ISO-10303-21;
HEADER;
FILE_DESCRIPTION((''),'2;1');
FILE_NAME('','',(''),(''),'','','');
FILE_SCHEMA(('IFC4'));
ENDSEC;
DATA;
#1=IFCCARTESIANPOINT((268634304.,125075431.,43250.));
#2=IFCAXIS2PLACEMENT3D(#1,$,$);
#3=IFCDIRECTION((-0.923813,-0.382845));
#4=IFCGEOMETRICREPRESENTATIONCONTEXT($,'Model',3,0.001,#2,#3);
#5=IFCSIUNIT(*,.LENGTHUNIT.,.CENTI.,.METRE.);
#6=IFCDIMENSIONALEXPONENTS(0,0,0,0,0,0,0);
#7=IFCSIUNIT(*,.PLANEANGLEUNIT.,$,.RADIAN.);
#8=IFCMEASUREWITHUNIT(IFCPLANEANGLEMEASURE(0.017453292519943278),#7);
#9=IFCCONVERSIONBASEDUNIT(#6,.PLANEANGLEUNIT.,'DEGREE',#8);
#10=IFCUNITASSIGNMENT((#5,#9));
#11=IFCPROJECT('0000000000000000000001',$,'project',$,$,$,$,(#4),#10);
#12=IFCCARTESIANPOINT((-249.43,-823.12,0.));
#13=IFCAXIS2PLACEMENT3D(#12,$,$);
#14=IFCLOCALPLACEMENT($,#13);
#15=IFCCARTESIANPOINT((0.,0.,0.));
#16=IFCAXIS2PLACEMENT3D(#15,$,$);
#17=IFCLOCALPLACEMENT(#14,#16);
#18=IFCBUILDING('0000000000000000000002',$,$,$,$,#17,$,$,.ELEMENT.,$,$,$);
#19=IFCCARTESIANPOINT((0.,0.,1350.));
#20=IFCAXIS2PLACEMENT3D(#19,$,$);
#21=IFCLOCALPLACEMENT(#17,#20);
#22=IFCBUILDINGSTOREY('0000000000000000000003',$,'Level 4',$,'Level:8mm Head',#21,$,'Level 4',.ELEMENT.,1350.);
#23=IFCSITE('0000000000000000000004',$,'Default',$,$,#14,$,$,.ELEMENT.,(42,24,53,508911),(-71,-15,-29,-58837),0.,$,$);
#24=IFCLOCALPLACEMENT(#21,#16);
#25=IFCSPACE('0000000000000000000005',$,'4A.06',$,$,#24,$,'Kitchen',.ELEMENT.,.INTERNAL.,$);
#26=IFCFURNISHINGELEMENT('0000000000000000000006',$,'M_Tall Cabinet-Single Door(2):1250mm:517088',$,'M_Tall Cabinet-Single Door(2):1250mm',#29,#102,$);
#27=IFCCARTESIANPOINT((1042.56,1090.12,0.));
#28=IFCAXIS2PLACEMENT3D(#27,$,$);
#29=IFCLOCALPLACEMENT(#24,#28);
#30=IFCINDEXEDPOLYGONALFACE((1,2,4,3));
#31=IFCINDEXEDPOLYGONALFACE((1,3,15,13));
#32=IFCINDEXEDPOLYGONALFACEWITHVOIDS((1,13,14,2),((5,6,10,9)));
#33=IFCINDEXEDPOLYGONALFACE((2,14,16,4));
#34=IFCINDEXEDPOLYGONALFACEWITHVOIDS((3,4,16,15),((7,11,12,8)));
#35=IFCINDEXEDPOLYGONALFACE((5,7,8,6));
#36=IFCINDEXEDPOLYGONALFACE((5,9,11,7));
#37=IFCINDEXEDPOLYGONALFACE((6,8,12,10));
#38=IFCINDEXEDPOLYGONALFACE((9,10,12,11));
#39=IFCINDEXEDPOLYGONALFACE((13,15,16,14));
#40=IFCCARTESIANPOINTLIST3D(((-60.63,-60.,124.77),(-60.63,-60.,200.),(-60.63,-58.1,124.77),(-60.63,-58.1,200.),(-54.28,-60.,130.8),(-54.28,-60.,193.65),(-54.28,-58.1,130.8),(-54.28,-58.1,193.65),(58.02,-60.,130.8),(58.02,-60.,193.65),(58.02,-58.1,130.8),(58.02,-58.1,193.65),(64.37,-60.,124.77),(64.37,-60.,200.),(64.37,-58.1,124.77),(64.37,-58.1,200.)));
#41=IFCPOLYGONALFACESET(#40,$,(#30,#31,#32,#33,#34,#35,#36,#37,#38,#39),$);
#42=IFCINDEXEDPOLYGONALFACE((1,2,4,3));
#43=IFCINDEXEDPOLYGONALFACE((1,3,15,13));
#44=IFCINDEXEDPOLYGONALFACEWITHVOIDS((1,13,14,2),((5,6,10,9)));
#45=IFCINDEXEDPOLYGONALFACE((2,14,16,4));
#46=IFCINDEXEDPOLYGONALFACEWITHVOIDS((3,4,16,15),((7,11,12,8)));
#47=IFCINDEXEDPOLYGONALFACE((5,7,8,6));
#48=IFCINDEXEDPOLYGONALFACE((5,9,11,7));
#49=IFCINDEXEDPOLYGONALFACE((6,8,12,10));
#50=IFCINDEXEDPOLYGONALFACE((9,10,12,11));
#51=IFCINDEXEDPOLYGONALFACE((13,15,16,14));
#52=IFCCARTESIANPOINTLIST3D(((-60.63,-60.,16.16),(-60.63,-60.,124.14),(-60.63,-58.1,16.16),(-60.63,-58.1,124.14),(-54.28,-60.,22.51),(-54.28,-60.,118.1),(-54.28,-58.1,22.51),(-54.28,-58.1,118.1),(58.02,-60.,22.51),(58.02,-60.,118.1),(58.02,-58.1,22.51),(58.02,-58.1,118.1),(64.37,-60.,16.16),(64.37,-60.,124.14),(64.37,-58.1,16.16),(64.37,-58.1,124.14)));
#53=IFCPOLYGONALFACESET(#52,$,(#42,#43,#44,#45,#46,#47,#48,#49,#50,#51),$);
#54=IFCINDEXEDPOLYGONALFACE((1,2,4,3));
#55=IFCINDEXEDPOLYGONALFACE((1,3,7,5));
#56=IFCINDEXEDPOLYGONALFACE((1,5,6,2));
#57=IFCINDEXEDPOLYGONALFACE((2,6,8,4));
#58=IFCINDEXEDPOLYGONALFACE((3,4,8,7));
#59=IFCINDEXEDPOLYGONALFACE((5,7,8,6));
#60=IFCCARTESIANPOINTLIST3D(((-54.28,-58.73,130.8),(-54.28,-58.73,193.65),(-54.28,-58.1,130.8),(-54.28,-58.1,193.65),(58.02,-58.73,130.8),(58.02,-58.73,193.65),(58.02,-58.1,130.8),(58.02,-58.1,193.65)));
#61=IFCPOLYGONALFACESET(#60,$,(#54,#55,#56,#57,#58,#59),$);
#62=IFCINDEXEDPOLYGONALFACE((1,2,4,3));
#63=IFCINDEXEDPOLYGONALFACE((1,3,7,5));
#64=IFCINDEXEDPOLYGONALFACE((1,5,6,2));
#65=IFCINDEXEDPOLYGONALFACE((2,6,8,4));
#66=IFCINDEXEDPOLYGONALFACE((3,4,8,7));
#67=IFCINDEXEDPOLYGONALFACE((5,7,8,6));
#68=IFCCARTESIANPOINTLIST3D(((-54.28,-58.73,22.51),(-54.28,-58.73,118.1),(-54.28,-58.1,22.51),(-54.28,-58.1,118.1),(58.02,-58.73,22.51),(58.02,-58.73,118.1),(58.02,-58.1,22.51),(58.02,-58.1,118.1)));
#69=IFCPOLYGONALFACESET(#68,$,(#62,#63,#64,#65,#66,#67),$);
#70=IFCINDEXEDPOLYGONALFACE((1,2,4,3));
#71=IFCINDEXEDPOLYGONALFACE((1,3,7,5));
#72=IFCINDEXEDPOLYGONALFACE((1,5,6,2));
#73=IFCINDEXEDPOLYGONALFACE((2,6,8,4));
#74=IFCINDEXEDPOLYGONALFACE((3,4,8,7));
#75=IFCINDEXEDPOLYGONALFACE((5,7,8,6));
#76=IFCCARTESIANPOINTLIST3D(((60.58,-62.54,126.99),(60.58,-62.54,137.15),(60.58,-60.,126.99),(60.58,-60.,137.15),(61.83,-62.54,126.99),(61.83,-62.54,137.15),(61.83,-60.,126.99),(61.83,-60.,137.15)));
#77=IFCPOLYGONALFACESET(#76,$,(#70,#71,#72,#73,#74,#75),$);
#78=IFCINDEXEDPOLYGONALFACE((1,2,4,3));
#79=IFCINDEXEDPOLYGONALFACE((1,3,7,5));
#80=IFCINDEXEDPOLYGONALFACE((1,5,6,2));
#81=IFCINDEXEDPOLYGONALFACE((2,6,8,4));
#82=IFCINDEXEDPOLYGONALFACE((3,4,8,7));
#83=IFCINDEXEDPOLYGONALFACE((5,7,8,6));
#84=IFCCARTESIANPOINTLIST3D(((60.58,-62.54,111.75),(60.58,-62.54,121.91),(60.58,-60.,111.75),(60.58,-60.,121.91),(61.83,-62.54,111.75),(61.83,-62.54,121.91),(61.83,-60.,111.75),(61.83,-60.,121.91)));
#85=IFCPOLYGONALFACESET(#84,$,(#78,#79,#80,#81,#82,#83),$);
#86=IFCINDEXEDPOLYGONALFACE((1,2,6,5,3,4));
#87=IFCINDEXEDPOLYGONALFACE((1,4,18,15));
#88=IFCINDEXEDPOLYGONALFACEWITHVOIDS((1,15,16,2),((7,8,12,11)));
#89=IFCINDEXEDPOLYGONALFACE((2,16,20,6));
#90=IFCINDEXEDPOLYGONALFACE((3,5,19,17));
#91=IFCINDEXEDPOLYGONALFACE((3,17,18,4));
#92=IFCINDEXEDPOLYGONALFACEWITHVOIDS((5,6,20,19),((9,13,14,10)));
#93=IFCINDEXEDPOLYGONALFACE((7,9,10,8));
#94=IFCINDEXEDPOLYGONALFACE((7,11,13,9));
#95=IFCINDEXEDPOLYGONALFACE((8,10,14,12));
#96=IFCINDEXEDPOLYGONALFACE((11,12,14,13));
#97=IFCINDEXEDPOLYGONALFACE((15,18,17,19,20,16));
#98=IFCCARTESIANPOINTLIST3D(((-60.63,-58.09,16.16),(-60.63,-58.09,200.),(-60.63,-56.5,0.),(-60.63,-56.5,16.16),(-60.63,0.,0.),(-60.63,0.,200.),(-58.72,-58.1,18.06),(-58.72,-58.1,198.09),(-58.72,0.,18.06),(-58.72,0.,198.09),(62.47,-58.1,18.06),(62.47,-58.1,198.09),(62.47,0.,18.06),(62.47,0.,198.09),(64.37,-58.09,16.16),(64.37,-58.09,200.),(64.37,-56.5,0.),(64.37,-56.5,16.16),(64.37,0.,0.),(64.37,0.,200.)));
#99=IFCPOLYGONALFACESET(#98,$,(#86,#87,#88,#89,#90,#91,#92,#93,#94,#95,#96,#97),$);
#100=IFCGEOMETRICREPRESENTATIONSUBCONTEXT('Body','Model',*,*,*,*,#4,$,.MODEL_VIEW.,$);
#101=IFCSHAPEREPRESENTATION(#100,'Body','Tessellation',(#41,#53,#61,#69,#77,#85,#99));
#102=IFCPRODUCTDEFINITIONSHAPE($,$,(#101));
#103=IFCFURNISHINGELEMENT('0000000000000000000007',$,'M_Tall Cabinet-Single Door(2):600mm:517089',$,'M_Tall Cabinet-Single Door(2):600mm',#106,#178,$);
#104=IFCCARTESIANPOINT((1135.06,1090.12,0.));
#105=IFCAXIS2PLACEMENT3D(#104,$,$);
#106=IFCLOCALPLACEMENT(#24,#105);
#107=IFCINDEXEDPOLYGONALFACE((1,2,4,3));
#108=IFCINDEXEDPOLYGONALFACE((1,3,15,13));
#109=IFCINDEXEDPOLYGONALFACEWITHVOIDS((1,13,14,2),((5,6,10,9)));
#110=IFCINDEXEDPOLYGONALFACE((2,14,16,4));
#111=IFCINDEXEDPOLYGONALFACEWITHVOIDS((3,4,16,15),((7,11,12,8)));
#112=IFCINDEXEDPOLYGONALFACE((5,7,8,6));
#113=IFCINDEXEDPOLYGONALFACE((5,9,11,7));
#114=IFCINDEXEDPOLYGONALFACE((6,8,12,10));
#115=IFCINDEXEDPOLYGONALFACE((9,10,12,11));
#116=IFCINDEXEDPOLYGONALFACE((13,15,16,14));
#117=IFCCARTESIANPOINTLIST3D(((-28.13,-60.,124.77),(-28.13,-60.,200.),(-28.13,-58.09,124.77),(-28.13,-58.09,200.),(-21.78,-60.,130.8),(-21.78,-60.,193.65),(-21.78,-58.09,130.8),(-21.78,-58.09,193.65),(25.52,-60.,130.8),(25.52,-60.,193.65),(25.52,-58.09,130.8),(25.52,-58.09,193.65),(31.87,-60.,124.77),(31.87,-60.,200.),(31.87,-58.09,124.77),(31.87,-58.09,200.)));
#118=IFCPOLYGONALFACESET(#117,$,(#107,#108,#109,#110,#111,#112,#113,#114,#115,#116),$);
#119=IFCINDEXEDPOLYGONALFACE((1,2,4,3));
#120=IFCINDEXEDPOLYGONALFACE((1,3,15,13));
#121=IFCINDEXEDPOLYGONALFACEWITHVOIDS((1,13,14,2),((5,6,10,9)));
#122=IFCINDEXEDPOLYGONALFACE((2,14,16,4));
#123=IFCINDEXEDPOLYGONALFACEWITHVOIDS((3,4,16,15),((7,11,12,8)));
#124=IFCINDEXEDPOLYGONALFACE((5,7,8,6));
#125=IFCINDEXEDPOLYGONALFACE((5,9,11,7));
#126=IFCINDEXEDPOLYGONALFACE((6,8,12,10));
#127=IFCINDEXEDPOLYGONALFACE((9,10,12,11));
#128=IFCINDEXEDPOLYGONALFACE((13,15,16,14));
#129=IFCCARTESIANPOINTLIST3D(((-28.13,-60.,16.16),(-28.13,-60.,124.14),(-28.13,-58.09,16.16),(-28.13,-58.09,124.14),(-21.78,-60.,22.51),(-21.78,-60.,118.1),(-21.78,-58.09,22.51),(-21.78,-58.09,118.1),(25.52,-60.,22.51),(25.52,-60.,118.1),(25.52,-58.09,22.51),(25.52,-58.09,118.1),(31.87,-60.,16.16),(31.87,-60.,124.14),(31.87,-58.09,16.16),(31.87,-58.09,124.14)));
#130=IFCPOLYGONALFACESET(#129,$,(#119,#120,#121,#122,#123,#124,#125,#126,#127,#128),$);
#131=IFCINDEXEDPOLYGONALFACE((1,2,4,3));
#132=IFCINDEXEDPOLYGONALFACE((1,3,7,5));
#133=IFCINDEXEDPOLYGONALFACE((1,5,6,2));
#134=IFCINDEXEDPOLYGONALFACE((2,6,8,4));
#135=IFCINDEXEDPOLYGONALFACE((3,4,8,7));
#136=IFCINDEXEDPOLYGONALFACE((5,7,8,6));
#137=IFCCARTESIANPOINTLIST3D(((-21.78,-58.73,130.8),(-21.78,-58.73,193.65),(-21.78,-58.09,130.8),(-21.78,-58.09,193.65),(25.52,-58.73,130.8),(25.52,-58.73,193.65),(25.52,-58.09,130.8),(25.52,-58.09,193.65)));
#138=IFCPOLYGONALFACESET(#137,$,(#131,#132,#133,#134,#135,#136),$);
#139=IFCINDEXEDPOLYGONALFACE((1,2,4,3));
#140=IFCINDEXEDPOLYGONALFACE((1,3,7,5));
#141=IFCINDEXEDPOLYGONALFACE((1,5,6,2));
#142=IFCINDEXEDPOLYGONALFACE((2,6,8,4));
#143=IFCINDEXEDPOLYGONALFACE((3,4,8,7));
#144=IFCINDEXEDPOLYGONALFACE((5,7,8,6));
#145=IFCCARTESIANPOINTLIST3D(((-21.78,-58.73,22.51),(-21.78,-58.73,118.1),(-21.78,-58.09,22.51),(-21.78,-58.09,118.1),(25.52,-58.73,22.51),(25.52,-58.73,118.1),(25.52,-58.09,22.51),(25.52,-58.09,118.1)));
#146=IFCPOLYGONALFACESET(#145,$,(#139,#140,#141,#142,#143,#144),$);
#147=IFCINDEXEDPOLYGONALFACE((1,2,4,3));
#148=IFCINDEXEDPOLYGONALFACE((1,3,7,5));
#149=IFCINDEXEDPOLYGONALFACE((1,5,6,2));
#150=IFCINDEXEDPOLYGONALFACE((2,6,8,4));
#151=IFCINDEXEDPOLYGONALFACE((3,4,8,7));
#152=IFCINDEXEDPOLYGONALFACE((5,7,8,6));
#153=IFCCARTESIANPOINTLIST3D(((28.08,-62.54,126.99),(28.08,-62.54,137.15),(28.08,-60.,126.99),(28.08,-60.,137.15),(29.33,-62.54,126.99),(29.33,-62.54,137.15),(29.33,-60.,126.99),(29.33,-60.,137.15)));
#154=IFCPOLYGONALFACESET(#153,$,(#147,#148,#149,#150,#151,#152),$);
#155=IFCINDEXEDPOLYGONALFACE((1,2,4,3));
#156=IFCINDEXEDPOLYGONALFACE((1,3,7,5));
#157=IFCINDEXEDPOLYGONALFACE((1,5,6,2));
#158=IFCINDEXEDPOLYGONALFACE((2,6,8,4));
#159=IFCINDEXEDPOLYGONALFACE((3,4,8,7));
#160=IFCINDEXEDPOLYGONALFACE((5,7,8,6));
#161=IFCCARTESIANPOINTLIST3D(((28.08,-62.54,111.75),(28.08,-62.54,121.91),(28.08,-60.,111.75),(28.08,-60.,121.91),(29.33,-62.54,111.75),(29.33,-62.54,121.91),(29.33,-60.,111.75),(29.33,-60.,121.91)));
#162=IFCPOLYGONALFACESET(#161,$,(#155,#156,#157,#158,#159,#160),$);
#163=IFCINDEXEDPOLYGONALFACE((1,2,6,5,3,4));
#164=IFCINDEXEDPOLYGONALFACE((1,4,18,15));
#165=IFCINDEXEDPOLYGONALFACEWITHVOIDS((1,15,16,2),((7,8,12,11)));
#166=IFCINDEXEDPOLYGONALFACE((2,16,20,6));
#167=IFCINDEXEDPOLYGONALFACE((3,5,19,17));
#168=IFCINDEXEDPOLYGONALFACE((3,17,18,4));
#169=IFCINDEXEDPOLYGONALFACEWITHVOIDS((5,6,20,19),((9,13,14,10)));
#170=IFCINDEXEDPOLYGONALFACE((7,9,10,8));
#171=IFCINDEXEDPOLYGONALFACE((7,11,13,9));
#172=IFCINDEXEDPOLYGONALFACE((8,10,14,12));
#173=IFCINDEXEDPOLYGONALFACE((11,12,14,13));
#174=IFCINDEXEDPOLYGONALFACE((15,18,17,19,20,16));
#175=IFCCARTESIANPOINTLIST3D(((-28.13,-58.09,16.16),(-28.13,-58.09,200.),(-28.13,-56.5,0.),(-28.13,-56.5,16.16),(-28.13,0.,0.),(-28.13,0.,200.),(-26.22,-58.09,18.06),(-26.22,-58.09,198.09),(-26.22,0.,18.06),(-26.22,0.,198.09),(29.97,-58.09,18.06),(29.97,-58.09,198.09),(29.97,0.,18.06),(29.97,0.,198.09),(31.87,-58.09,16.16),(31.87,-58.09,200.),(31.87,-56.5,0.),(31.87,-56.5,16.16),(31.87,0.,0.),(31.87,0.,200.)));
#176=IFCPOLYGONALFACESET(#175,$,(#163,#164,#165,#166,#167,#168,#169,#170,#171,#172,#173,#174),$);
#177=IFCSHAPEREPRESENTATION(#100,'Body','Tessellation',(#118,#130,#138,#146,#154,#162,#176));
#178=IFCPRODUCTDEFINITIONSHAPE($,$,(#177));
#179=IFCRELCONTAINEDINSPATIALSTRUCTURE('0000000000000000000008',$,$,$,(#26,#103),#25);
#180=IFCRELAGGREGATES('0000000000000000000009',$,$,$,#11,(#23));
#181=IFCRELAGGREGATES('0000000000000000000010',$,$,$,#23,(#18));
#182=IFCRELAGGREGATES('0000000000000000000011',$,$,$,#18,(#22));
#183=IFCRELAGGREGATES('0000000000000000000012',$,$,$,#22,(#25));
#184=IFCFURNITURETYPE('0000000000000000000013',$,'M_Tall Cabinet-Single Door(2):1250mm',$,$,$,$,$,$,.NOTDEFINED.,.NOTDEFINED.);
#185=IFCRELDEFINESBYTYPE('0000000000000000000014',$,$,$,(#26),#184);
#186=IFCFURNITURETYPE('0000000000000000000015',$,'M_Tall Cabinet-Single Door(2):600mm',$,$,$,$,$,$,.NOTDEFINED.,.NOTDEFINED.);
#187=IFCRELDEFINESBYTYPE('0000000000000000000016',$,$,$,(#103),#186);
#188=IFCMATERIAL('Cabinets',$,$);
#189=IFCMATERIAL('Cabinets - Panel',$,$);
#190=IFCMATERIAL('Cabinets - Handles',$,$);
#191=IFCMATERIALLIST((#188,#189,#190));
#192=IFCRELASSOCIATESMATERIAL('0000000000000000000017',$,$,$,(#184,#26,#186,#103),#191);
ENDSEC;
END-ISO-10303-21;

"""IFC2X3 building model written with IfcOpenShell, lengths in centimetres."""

from ifc_helpers import new_model, entity, si_unit, converted_unit, direction, frame, frame_2d, origin, origin_2d_with_axis, place, context, subcontext, project, spatial, polyline, rectangle, outline, extrude, source, transform, mapped, material, material_list, type_object, type_shapes, element, save


model = new_model("IFC2X3")

# Units and contexts
model_context = context("Model", 3, precision=0.001, world=frame((268634304.0, 125075431.0, 43250.0)), true_north=direction((-0.923813, -0.382845)))
body_context = subcontext(model_context, "Body", "Model", "MODEL_VIEW")
ifc_project = project(units=[si_unit("LENGTHUNIT", "METRE", prefix="CENTI"), converted_unit("PLANEANGLEUNIT", "DEGREE", entity("IfcPlaneAngleMeasure", 0.017453292519943278), si_unit("PLANEANGLEUNIT", "RADIAN"), dimensions=[0, 0, 0, 0, 0, 0, 0])], contexts=[model_context])

# Site, building, storey
site_placement = place(None, frame((-249.43, -823.12, 0.0)))
site = spatial("IfcSite", under=ifc_project, at=site_placement, Name="Default", CompositionType="ELEMENT", RefLatitude=(42, 24, 53, 508911), RefLongitude=(-71, -15, -29, -58837), RefElevation=0.0)
building_placement = place(site_placement, origin())
building = spatial("IfcBuilding", under=site, at=building_placement, CompositionType="ELEMENT")
storey_placement = place(building_placement, frame((0.0, 0.0, 1350.0)))
storey = spatial("IfcBuildingStorey", under=building, at=storey_placement, Name="Level 4", ObjectType="Level:8mm Head", LongName="Level 4", CompositionType="ELEMENT", Elevation=1350.0)

# Shared definitions
space_1_placement = place(storey_placement, origin())
space_1 = spatial("IfcSpace", under=storey, at=space_1_placement, Name="4A.06", LongName="Kitchen", CompositionType="ELEMENT", InteriorOrExteriorSpace="INTERNAL")

# Furnishing elements, openings
ifc_material_1 = material(Name="Cabinets")
ifc_material_2 = material(Name="Cabinets - Panel")
ifc_material_3 = material(Name="Cabinets - Handles")
ifc_material_list_1 = material_list([ifc_material_1, ifc_material_2, ifc_material_3])
furniture_type_1 = type_object("IfcFurnitureType", Name="M_Tall Cabinet-Single Door(2):1250mm", AssemblyPlace="NOTDEFINED", material=ifc_material_list_1)
shared_shape_1 = source(origin(), body_context, "Body", "SweptSolid", [
    extrude(rectangle(XDim=1.91, YDim=121.19, at=origin_2d_with_axis()), frame((1.87, -0.95, 18.06), z_axis=(0.0, 0.0, 1.0), x_axis=(0.0, 1.0, 0.0)), (0.0, 0.0, 1.0), 180.03),
    extrude(outline(polyline([(-37.61, -62.5), (37.61, -62.5), (37.61, 62.5), (-37.61, 62.5), (-37.61, -62.5)]), holes=[polyline([(-31.26, -56.15), (-31.26, 56.15), (31.58, 56.15), (31.58, -56.15), (-31.26, -56.15)])]), frame((1.87, -60.0, 162.39), z_axis=(0.0, 1.0, 0.0), x_axis=(0.0, 0.0, -1.0)), (0.0, 0.0, 1.0), 1.91),
    extrude(outline(polyline([(-62.5, -53.99), (62.5, -53.99), (62.5, 53.99), (-62.5, 53.99), (-62.5, -53.99)]), holes=[polyline([(-56.15, 47.96), (56.15, 47.96), (56.15, -47.64), (-56.15, -47.64), (-56.15, 47.96)])]), frame((1.87, -60.0, 70.15), z_axis=(0.0, 1.0, 0.0), x_axis=(-1.0, 0.0, 0.0)), (0.0, 0.0, 1.0), 1.91),
    extrude(rectangle(XDim=0.63, YDim=112.3, at=frame_2d((0.0, 0.0), x_axis=(1.0, 0.0))), frame((1.87, -58.41, 130.8), z_axis=(0.0, 0.0, 1.0), x_axis=(0.0, 1.0, 0.0)), (0.0, 0.0, 1.0), 62.85),
    extrude(rectangle(XDim=0.63, YDim=112.3, at=frame_2d((0.0, 0.0), x_axis=(1.0, 0.0))), frame((1.87, -58.41, 22.51), z_axis=(0.0, 0.0, 1.0), x_axis=(0.0, 1.0, 0.0)), (0.0, 0.0, 1.0), 95.6),
    extrude(rectangle(XDim=2.54, YDim=1.25, at=frame_2d((0.0, 0.0), x_axis=(1.0, 0.0))), frame((61.21, -61.27, 126.99), z_axis=(0.0, 0.0, 1.0), x_axis=(0.0, 1.0, 0.0)), (0.0, 0.0, 1.0), 10.16),
    extrude(rectangle(XDim=2.54, YDim=1.25, at=frame_2d((0.0, 0.0), x_axis=(1.0, 0.0))), frame((61.21, -61.27, 111.75), z_axis=(0.0, 0.0, 1.0), x_axis=(0.0, 1.0, 0.0)), (0.0, 0.0, 1.0), 10.16),
    extrude(outline(polyline([(-19.9, 55.89), (-19.9, -127.95), (38.2, -127.95), (38.2, 72.05), (-18.3, 72.05), (-18.3, 55.89), (-19.9, 55.89)])), frame((-60.63, -38.2, 72.05), z_axis=(-1.0, 0.0, 0.0), x_axis=(0.0, 1.0, 0.0)), (0.0, 0.0, -1.0), 125.0),
])
type_shapes(furniture_type_1, [shared_shape_1])
furnishing_1_placement = place(space_1_placement, frame((1042.56, 1090.12, 0.0)))
furnishing_1 = element("IfcFurnishingElement", 1, at=furnishing_1_placement, inside=space_1, type_object=furniture_type_1, material=ifc_material_list_1, Name="M_Tall Cabinet-Single Door(2):1250mm:517088", ObjectType="M_Tall Cabinet-Single Door(2):1250mm", context=body_context, shape_type="MappedRepresentation", body=[
    mapped(shared_shape_1, transform((0.0, 0.0, 0.0), scale=1.0)),
])
opening_1_placement = place(storey_placement, frame((1042.56, 1090.12, 1350.0)))
element("IfcOpeningElement", 2, at=opening_1_placement, cuts=furnishing_1, ObjectType="Opening", context=body_context, shape_type="SweptSolid", body=[
    extrude(rectangle(XDim=180.03, YDim=121.19, at=frame_2d((0.0, 0.0), x_axis=(0.0, 1.0))), frame((1.87, 0.0, -1241.92), z_axis=(0.0, -1.0, 0.0), x_axis=(-1.0, 0.0, 0.0)), (0.0, 0.0, 1.0), 58.09),
])
furniture_type_2 = type_object("IfcFurnitureType", Name="M_Tall Cabinet-Single Door(2):600mm", AssemblyPlace="NOTDEFINED", material=ifc_material_list_1)
shared_shape_2 = source(origin(), body_context, "Body", "SweptSolid", [
    extrude(rectangle(XDim=1.91, YDim=56.19, at=origin_2d_with_axis()), frame((1.87, -0.95, 18.06), z_axis=(0.0, 0.0, 1.0), x_axis=(0.0, 1.0, 0.0)), (0.0, 0.0, 1.0), 180.03),
    extrude(outline(polyline([(-37.61, -30.0), (37.61, -30.0), (37.61, 30.0), (-37.61, 30.0), (-37.61, -30.0)]), holes=[polyline([(-31.26, -23.65), (-31.26, 23.65), (31.58, 23.65), (31.58, -23.65), (-31.26, -23.65)])]), frame((1.87, -60.0, 162.39), z_axis=(0.0, 1.0, 0.0), x_axis=(0.0, 0.0, -1.0)), (0.0, 0.0, 1.0), 1.91),
    extrude(outline(polyline([(-30.0, -53.99), (30.0, -53.99), (30.0, 53.99), (-30.0, 53.99), (-30.0, -53.99)]), holes=[polyline([(-23.65, 47.96), (23.65, 47.96), (23.65, -47.64), (-23.65, -47.64), (-23.65, 47.96)])]), frame((1.87, -60.0, 70.15), z_axis=(0.0, 1.0, 0.0), x_axis=(-1.0, 0.0, 0.0)), (0.0, 0.0, 1.0), 1.91),
    extrude(rectangle(XDim=0.63, YDim=47.3, at=origin_2d_with_axis()), frame((1.87, -58.41, 130.8), z_axis=(0.0, 0.0, 1.0), x_axis=(0.0, 1.0, 0.0)), (0.0, 0.0, 1.0), 62.85),
    extrude(rectangle(XDim=0.63, YDim=47.3, at=origin_2d_with_axis()), frame((1.87, -58.41, 22.51), z_axis=(0.0, 0.0, 1.0), x_axis=(0.0, 1.0, 0.0)), (0.0, 0.0, 1.0), 95.6),
    extrude(rectangle(XDim=2.54, YDim=1.25, at=frame_2d((0.0, 0.0), x_axis=(1.0, 0.0))), frame((28.71, -61.27, 126.99), z_axis=(0.0, 0.0, 1.0), x_axis=(0.0, 1.0, 0.0)), (0.0, 0.0, 1.0), 10.16),
    extrude(rectangle(XDim=2.54, YDim=1.25, at=frame_2d((0.0, 0.0), x_axis=(1.0, 0.0))), frame((28.71, -61.27, 111.75), z_axis=(0.0, 0.0, 1.0), x_axis=(0.0, 1.0, 0.0)), (0.0, 0.0, 1.0), 10.16),
    extrude(outline(polyline([(-19.9, 55.89), (-19.9, -127.95), (38.2, -127.95), (38.2, 72.05), (-18.3, 72.05), (-18.3, 55.89), (-19.9, 55.89)])), frame((-28.13, -38.2, 72.05), z_axis=(-1.0, 0.0, 0.0), x_axis=(0.0, 1.0, 0.0)), (0.0, 0.0, -1.0), 60.0),
])
type_shapes(furniture_type_2, [shared_shape_2])
furnishing_2_placement = place(space_1_placement, frame((1135.06, 1090.12, 0.0)))
furnishing_2 = element("IfcFurnishingElement", 3, at=furnishing_2_placement, inside=space_1, type_object=furniture_type_2, material=ifc_material_list_1, Name="M_Tall Cabinet-Single Door(2):600mm:517089", ObjectType="M_Tall Cabinet-Single Door(2):600mm", context=body_context, shape_type="MappedRepresentation", body=[
    mapped(shared_shape_2, transform((0.0, 0.0, 0.0), scale=1.0)),
])
opening_2_placement = place(storey_placement, frame((1135.06, 1090.12, 1350.0)))
element("IfcOpeningElement", 4, at=opening_2_placement, cuts=furnishing_2, ObjectType="Opening", context=body_context, shape_type="SweptSolid", body=[
    extrude(rectangle(XDim=180.03, YDim=56.19, at=frame_2d((0.0, 0.0), x_axis=(0.0, 1.0))), frame((1.87, 0.0, -1241.92), z_axis=(0.0, -1.0, 0.0), x_axis=(-1.0, 0.0, 0.0)), (0.0, 0.0, 1.0), 58.09),
])

save(model, "model.ifc")
